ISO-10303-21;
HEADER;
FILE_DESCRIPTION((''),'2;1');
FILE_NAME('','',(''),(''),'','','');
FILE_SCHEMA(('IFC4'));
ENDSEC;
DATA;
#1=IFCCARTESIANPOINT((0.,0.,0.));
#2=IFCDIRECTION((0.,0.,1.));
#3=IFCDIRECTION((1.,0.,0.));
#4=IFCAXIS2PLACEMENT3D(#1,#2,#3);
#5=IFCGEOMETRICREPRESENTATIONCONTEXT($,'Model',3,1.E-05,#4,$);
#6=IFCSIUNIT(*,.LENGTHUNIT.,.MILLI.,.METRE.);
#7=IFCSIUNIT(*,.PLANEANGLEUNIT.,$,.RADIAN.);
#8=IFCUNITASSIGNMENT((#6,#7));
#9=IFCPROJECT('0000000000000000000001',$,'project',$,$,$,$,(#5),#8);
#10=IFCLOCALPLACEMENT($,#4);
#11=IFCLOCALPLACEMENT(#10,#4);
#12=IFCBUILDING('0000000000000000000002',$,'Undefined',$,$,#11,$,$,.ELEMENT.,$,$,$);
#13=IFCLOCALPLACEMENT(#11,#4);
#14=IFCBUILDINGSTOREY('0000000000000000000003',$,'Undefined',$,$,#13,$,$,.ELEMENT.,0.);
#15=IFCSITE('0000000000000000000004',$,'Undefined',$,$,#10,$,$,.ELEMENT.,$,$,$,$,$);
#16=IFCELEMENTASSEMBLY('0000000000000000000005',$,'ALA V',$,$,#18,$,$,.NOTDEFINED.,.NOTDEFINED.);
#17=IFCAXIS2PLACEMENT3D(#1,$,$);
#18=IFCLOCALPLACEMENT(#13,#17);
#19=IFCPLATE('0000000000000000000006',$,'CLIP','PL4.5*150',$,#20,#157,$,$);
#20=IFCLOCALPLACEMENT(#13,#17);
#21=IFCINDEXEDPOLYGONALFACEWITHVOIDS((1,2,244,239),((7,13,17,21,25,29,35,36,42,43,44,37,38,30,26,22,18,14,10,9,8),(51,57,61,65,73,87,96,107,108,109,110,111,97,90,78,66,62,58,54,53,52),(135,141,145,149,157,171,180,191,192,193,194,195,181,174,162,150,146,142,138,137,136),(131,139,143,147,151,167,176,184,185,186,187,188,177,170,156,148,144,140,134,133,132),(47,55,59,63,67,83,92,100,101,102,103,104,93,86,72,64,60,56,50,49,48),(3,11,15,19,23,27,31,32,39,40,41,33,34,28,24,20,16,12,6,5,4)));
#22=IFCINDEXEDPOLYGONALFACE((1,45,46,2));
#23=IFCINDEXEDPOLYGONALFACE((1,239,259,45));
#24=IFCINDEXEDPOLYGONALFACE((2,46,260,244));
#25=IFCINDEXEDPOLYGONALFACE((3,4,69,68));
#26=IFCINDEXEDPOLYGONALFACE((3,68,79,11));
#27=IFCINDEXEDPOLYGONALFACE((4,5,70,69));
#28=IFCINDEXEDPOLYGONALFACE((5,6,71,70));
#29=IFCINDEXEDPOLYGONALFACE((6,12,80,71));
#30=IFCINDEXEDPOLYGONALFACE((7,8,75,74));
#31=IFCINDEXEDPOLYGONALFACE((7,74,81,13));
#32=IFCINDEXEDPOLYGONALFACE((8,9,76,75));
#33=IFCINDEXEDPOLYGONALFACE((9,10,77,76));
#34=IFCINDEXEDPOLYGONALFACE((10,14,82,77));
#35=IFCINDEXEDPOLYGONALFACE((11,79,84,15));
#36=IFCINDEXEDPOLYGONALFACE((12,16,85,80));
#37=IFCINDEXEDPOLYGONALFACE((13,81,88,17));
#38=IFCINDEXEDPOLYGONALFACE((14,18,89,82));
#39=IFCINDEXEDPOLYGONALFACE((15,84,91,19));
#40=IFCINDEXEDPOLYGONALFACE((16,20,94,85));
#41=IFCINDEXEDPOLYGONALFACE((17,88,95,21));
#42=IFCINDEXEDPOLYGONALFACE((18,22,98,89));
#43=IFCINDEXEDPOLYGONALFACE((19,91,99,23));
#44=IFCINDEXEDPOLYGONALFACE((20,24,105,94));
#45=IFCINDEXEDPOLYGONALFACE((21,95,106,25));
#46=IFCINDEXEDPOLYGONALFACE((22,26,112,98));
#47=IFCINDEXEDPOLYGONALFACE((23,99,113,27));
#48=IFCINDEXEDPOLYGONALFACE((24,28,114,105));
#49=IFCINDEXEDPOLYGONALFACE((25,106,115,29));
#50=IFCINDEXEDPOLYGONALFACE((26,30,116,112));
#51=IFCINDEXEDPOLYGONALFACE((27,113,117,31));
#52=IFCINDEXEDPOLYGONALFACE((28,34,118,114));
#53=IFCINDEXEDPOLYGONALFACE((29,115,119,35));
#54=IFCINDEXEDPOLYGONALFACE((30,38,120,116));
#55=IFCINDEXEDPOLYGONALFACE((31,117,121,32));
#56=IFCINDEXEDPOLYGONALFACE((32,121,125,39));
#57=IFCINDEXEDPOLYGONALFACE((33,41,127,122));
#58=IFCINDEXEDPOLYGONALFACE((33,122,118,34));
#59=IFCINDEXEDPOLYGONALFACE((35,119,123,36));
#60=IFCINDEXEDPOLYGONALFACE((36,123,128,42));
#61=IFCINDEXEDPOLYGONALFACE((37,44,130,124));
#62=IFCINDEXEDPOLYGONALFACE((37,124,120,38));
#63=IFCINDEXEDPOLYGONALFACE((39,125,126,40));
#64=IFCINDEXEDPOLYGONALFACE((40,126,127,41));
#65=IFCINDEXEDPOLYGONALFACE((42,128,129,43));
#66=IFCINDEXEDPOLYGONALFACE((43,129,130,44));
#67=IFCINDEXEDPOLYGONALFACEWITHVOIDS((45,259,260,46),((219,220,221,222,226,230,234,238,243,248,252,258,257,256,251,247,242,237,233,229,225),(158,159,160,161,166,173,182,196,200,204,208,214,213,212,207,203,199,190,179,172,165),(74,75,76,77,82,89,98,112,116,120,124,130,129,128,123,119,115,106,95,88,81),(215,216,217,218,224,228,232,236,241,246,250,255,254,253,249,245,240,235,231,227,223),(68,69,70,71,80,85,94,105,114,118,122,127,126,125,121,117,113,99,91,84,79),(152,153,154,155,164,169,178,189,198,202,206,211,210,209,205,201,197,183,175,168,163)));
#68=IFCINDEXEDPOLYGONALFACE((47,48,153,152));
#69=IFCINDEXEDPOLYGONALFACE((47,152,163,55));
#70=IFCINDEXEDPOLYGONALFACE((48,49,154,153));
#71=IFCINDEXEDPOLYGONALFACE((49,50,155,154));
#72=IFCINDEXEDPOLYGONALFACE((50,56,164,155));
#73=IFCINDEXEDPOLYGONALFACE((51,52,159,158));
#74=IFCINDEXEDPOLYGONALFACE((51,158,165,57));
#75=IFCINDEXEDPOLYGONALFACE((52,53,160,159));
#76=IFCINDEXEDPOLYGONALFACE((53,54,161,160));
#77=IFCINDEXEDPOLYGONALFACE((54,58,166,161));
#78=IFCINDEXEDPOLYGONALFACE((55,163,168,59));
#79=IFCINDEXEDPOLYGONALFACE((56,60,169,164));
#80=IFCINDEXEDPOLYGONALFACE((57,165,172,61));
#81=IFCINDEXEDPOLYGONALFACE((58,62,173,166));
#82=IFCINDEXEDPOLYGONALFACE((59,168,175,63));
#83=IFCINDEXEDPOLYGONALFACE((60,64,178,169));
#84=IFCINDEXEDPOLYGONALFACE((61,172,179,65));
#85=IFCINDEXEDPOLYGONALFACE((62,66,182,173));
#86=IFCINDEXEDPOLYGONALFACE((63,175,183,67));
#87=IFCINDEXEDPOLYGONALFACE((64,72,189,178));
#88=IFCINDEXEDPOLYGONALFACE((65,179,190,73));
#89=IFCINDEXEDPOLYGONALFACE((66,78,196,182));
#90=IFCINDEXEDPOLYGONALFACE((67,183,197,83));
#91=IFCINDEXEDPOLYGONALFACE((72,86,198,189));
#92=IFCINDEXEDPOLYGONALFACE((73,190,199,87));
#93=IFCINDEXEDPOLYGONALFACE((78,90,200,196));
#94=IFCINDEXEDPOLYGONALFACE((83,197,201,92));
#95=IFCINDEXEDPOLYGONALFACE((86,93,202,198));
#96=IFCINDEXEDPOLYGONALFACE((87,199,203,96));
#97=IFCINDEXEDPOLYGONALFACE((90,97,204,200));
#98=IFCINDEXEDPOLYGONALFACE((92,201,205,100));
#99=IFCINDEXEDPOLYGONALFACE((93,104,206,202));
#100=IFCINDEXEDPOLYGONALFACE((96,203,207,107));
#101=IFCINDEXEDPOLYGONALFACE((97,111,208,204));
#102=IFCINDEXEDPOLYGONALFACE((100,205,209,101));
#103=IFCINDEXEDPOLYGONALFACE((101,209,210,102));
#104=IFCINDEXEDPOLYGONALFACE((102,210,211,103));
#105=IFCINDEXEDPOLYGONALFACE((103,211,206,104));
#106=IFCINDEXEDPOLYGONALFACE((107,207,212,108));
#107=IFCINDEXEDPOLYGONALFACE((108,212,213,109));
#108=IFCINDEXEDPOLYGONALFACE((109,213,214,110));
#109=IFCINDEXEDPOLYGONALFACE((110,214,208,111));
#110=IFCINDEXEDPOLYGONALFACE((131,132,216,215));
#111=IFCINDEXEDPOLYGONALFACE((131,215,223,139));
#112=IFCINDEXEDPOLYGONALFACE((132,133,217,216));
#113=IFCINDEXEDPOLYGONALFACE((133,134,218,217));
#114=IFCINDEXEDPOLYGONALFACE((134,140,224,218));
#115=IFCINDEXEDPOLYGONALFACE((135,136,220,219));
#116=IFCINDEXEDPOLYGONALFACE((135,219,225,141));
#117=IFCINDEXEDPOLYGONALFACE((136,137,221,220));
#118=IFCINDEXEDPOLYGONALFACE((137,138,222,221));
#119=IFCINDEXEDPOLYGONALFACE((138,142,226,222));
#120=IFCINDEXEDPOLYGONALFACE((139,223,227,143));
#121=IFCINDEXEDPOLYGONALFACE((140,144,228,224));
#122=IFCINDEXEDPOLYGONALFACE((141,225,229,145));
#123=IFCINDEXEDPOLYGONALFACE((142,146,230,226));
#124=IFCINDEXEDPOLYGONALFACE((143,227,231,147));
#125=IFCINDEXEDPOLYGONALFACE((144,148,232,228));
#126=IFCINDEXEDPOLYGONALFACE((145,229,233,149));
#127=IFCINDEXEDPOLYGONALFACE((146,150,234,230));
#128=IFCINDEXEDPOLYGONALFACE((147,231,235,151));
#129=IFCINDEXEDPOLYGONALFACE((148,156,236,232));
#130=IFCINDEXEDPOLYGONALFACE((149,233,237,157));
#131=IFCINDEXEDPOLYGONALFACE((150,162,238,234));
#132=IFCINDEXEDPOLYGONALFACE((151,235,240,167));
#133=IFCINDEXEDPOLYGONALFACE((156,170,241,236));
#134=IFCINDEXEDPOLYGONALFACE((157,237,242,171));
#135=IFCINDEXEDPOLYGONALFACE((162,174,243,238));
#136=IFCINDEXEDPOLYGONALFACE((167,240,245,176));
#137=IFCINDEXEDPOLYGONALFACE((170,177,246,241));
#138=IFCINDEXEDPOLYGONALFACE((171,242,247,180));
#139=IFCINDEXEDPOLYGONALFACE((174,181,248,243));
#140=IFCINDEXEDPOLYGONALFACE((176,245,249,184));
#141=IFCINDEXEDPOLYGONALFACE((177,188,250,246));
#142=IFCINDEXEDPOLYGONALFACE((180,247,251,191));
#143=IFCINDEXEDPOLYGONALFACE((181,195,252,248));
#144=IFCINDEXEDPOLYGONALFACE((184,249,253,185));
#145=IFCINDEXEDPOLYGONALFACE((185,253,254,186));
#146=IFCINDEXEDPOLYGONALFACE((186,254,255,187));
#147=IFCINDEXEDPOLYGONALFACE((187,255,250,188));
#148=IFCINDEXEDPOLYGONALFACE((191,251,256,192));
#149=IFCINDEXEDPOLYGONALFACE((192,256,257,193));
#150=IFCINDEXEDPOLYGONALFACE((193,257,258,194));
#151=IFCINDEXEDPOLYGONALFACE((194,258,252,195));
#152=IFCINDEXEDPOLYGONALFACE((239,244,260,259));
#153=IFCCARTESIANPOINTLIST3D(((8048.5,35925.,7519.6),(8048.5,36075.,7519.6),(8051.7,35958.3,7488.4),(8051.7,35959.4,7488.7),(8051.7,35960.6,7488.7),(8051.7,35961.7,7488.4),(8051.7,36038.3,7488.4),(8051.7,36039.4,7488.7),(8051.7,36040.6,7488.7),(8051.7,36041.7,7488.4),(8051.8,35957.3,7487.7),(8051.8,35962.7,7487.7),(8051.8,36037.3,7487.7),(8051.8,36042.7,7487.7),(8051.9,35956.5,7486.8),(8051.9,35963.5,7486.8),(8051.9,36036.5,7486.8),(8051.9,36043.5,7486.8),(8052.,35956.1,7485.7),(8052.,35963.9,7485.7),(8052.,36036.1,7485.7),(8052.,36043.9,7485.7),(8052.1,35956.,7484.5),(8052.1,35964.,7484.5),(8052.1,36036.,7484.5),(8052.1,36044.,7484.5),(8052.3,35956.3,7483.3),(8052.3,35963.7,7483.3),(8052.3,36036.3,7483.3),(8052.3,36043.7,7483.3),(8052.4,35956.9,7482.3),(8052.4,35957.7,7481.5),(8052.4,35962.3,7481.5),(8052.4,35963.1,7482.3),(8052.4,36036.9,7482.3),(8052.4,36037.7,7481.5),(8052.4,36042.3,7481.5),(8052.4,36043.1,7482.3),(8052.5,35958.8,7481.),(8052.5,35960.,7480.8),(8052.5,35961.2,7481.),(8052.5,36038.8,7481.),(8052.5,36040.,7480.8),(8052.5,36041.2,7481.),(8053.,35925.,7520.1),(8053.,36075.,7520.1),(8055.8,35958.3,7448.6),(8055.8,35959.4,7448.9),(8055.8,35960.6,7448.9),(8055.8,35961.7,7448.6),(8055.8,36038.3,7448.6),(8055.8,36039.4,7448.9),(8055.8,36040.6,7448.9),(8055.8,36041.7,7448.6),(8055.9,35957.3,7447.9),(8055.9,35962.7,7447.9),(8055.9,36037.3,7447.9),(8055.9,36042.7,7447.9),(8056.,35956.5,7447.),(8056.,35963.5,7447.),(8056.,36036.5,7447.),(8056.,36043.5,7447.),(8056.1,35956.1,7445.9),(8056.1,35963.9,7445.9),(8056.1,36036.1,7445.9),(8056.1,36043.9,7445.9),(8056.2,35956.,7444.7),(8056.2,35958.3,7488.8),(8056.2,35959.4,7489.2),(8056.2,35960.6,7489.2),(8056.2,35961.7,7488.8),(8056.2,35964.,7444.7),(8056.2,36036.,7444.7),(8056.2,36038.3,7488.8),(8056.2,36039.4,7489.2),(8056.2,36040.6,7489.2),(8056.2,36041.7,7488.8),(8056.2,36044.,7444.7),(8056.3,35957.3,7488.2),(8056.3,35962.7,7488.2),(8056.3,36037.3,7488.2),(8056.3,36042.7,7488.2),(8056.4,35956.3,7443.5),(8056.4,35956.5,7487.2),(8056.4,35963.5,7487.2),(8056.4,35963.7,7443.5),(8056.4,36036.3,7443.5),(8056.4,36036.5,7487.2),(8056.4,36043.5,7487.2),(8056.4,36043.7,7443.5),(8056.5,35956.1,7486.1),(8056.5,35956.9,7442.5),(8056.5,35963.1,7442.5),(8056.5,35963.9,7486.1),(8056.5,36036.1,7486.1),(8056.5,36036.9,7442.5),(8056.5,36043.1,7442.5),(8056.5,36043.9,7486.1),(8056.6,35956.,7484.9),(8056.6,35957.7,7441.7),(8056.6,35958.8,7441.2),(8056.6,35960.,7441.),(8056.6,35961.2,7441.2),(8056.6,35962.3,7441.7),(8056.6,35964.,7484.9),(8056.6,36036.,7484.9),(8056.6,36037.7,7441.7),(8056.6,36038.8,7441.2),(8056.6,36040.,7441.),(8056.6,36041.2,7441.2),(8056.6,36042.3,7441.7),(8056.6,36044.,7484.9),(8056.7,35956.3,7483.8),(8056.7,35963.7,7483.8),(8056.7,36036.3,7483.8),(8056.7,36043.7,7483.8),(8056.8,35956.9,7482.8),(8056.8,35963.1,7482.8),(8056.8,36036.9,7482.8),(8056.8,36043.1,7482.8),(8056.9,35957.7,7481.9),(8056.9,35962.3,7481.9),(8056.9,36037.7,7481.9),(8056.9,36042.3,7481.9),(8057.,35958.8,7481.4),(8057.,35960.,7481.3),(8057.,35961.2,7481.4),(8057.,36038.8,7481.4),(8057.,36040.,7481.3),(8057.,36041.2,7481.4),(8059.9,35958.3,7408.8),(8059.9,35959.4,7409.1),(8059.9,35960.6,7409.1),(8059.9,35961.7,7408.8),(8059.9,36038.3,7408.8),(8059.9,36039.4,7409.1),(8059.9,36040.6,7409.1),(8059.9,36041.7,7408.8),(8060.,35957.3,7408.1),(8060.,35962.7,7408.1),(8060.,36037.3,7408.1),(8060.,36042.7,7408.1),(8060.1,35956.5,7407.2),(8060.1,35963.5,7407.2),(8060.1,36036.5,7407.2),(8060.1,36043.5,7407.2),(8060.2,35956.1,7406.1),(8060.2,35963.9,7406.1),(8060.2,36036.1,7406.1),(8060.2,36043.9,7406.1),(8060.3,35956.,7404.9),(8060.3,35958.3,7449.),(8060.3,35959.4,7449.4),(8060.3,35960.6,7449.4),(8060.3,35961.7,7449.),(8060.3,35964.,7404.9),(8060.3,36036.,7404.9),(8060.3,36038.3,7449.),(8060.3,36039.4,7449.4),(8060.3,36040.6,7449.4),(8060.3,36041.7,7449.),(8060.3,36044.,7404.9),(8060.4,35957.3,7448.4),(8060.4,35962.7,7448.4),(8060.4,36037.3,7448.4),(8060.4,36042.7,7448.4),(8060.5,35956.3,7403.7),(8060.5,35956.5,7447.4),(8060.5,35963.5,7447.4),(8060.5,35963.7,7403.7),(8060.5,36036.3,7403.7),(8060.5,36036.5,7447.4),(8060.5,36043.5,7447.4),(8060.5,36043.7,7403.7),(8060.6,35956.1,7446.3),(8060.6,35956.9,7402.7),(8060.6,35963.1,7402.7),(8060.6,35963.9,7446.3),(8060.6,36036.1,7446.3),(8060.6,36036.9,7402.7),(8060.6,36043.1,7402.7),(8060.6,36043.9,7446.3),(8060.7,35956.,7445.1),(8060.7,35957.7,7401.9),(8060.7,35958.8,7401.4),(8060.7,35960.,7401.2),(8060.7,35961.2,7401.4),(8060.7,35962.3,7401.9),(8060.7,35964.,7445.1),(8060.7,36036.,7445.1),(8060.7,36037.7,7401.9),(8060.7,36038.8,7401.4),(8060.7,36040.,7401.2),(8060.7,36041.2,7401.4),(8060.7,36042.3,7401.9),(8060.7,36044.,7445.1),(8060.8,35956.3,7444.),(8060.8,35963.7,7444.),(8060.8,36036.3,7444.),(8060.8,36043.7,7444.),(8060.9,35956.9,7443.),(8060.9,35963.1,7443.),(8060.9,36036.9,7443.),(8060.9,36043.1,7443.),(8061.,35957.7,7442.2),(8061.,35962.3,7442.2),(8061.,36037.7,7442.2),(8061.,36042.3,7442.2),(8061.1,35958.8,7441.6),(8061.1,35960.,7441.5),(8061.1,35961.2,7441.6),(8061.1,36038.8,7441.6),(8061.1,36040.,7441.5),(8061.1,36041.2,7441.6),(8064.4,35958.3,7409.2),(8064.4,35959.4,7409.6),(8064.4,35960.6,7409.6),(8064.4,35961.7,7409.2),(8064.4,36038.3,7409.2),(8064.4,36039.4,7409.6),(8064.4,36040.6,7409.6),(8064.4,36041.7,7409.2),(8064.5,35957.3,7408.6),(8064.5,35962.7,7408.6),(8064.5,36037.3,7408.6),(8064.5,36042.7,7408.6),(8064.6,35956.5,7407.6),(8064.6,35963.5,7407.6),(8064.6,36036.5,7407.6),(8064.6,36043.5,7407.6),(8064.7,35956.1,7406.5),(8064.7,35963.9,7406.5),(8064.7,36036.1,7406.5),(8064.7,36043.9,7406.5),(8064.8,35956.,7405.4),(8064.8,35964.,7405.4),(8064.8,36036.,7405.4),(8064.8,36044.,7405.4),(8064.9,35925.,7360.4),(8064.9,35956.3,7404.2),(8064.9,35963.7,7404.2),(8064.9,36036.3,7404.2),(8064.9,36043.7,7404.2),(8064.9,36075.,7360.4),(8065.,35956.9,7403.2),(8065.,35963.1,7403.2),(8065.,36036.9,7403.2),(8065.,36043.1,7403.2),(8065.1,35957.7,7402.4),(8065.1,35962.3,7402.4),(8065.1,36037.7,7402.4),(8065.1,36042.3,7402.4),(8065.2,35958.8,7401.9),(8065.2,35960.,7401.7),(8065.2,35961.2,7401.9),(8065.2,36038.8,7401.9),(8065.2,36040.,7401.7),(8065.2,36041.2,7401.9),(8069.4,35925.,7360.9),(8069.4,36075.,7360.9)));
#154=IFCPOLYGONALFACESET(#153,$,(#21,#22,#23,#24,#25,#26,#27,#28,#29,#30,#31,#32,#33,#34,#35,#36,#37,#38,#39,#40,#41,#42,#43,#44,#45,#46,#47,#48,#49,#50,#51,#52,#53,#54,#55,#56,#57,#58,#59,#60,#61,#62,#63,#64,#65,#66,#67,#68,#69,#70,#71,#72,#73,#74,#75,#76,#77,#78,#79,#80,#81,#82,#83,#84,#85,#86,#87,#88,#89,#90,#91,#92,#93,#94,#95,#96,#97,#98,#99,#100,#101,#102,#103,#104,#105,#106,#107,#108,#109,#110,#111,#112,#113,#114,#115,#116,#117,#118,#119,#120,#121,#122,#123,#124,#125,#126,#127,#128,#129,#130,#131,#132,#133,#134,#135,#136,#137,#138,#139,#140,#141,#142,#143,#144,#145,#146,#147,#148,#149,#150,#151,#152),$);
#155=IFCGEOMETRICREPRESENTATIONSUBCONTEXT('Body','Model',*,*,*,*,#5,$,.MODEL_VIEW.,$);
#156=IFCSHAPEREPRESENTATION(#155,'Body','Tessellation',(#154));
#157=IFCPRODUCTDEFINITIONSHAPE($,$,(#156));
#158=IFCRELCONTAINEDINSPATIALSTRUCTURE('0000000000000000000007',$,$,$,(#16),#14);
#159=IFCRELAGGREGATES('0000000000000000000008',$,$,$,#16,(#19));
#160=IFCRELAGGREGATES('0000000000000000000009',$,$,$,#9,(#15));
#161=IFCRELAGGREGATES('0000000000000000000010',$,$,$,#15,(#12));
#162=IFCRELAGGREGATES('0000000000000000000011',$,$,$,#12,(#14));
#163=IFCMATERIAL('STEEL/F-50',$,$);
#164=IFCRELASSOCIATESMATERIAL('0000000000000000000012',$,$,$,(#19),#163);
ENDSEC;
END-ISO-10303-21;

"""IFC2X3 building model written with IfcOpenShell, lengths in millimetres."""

from ifc_helpers import new_model, si_unit, frame, origin_with_axes, origin_2d_with_axis, place, context, subcontext, project, spatial, polyline, circle, outline, extrude, source, transform, mapped, material, element, aggregate, save


model = new_model("IFC2X3")

# Units and contexts
model_context = context("Model", 3, precision=1e-05, world=origin_with_axes())
body_context = subcontext(model_context, "Body", "Model", "MODEL_VIEW")
ifc_project = project(units=[si_unit("LENGTHUNIT", "METRE", prefix="MILLI"), si_unit("PLANEANGLEUNIT", "RADIAN")], contexts=[model_context])

# Site, building, storey
site_placement = place(None, origin_with_axes())
site = spatial("IfcSite", under=ifc_project, at=site_placement, Name="Undefined", CompositionType="ELEMENT")
building_placement = place(site_placement, origin_with_axes())
building = spatial("IfcBuilding", under=site, at=building_placement, Name="Undefined", CompositionType="ELEMENT")
storey_placement = place(building_placement, origin_with_axes())
storey = spatial("IfcBuildingStorey", under=building, at=storey_placement, Name="Undefined", CompositionType="ELEMENT", Elevation=0.0)

# Element assembly
assembly_1_placement = place(storey_placement, origin_with_axes())
assembly_1 = element("IfcElementAssembly", 1, at=assembly_1_placement, inside=storey, Name="ALA V", AssemblyPlace="NOTDEFINED", PredefinedType="NOTDEFINED")
ifc_material_1 = material(Name="STEEL/F-50")

# Plate, openings
shared_shape_1 = source(origin_with_axes(), body_context, "Body", "SweptSolid", [
    extrude(circle(Radius=4.0, at=origin_2d_with_axis()), frame((0.0, -4.6, 0.0), z_axis=(0.0, 1.0, 0.0), x_axis=(1.0, 0.0, 0.0)), (0.0, 0.0, 1.0), 4.7),
])
plate_1_placement = place(assembly_1_placement, frame((8050.8, 35925.0, 7519.8), z_axis=(0.994727, 0.0, 0.102562), x_axis=(0.102562, 0.0, -0.994727)))
plate_1 = element("IfcPlate", 2, at=plate_1_placement, material=ifc_material_1, Name="CLIP", Description="PL4.5*150", context=body_context, shape_type="SweptSolid", body=[
    extrude(outline(polyline([(0.0, 0.0), (160.0, 0.0), (160.0, 150.0), (0.0, 150.0), (0.0, 0.0)])), frame((0.0, 0.0, -2.2), z_axis=(0.0, 0.0, 1.0), x_axis=(1.0, 0.0, 0.0)), (0.0, 0.0, 1.0), 4.5),
])
opening_1_placement = place(assembly_1_placement, frame((8052.1, 36040.0, 7484.8), z_axis=(0.0, 1.0, 0.0), x_axis=(0.102562, 0.0, -0.994727)))
element("IfcOpeningElement", 3, at=opening_1_placement, cuts=plate_1, ObjectType="Opening", context=body_context, shape_type="MappedRepresentation", body=[
    mapped(shared_shape_1, transform((0.0, 0.0, 0.0))),
    mapped(shared_shape_1, transform((40.0, 0.0, 0.0))),
    mapped(shared_shape_1, transform((80.0, 0.0, 0.0))),
])
opening_2_placement = place(assembly_1_placement, frame((8052.1, 35960.0, 7484.8), z_axis=(0.0, 1.0, 0.0), x_axis=(0.102562, 0.0, -0.994727)))
element("IfcOpeningElement", 4, at=opening_2_placement, cuts=plate_1, ObjectType="Opening", context=body_context, shape_type="MappedRepresentation", body=[
    mapped(shared_shape_1, transform((0.0, 0.0, 0.0))),
    mapped(shared_shape_1, transform((40.0, 0.0, 0.0))),
    mapped(shared_shape_1, transform((80.0, 0.0, 0.0))),
])

aggregate(assembly_1, [plate_1])

save(model, "model.ifc")
